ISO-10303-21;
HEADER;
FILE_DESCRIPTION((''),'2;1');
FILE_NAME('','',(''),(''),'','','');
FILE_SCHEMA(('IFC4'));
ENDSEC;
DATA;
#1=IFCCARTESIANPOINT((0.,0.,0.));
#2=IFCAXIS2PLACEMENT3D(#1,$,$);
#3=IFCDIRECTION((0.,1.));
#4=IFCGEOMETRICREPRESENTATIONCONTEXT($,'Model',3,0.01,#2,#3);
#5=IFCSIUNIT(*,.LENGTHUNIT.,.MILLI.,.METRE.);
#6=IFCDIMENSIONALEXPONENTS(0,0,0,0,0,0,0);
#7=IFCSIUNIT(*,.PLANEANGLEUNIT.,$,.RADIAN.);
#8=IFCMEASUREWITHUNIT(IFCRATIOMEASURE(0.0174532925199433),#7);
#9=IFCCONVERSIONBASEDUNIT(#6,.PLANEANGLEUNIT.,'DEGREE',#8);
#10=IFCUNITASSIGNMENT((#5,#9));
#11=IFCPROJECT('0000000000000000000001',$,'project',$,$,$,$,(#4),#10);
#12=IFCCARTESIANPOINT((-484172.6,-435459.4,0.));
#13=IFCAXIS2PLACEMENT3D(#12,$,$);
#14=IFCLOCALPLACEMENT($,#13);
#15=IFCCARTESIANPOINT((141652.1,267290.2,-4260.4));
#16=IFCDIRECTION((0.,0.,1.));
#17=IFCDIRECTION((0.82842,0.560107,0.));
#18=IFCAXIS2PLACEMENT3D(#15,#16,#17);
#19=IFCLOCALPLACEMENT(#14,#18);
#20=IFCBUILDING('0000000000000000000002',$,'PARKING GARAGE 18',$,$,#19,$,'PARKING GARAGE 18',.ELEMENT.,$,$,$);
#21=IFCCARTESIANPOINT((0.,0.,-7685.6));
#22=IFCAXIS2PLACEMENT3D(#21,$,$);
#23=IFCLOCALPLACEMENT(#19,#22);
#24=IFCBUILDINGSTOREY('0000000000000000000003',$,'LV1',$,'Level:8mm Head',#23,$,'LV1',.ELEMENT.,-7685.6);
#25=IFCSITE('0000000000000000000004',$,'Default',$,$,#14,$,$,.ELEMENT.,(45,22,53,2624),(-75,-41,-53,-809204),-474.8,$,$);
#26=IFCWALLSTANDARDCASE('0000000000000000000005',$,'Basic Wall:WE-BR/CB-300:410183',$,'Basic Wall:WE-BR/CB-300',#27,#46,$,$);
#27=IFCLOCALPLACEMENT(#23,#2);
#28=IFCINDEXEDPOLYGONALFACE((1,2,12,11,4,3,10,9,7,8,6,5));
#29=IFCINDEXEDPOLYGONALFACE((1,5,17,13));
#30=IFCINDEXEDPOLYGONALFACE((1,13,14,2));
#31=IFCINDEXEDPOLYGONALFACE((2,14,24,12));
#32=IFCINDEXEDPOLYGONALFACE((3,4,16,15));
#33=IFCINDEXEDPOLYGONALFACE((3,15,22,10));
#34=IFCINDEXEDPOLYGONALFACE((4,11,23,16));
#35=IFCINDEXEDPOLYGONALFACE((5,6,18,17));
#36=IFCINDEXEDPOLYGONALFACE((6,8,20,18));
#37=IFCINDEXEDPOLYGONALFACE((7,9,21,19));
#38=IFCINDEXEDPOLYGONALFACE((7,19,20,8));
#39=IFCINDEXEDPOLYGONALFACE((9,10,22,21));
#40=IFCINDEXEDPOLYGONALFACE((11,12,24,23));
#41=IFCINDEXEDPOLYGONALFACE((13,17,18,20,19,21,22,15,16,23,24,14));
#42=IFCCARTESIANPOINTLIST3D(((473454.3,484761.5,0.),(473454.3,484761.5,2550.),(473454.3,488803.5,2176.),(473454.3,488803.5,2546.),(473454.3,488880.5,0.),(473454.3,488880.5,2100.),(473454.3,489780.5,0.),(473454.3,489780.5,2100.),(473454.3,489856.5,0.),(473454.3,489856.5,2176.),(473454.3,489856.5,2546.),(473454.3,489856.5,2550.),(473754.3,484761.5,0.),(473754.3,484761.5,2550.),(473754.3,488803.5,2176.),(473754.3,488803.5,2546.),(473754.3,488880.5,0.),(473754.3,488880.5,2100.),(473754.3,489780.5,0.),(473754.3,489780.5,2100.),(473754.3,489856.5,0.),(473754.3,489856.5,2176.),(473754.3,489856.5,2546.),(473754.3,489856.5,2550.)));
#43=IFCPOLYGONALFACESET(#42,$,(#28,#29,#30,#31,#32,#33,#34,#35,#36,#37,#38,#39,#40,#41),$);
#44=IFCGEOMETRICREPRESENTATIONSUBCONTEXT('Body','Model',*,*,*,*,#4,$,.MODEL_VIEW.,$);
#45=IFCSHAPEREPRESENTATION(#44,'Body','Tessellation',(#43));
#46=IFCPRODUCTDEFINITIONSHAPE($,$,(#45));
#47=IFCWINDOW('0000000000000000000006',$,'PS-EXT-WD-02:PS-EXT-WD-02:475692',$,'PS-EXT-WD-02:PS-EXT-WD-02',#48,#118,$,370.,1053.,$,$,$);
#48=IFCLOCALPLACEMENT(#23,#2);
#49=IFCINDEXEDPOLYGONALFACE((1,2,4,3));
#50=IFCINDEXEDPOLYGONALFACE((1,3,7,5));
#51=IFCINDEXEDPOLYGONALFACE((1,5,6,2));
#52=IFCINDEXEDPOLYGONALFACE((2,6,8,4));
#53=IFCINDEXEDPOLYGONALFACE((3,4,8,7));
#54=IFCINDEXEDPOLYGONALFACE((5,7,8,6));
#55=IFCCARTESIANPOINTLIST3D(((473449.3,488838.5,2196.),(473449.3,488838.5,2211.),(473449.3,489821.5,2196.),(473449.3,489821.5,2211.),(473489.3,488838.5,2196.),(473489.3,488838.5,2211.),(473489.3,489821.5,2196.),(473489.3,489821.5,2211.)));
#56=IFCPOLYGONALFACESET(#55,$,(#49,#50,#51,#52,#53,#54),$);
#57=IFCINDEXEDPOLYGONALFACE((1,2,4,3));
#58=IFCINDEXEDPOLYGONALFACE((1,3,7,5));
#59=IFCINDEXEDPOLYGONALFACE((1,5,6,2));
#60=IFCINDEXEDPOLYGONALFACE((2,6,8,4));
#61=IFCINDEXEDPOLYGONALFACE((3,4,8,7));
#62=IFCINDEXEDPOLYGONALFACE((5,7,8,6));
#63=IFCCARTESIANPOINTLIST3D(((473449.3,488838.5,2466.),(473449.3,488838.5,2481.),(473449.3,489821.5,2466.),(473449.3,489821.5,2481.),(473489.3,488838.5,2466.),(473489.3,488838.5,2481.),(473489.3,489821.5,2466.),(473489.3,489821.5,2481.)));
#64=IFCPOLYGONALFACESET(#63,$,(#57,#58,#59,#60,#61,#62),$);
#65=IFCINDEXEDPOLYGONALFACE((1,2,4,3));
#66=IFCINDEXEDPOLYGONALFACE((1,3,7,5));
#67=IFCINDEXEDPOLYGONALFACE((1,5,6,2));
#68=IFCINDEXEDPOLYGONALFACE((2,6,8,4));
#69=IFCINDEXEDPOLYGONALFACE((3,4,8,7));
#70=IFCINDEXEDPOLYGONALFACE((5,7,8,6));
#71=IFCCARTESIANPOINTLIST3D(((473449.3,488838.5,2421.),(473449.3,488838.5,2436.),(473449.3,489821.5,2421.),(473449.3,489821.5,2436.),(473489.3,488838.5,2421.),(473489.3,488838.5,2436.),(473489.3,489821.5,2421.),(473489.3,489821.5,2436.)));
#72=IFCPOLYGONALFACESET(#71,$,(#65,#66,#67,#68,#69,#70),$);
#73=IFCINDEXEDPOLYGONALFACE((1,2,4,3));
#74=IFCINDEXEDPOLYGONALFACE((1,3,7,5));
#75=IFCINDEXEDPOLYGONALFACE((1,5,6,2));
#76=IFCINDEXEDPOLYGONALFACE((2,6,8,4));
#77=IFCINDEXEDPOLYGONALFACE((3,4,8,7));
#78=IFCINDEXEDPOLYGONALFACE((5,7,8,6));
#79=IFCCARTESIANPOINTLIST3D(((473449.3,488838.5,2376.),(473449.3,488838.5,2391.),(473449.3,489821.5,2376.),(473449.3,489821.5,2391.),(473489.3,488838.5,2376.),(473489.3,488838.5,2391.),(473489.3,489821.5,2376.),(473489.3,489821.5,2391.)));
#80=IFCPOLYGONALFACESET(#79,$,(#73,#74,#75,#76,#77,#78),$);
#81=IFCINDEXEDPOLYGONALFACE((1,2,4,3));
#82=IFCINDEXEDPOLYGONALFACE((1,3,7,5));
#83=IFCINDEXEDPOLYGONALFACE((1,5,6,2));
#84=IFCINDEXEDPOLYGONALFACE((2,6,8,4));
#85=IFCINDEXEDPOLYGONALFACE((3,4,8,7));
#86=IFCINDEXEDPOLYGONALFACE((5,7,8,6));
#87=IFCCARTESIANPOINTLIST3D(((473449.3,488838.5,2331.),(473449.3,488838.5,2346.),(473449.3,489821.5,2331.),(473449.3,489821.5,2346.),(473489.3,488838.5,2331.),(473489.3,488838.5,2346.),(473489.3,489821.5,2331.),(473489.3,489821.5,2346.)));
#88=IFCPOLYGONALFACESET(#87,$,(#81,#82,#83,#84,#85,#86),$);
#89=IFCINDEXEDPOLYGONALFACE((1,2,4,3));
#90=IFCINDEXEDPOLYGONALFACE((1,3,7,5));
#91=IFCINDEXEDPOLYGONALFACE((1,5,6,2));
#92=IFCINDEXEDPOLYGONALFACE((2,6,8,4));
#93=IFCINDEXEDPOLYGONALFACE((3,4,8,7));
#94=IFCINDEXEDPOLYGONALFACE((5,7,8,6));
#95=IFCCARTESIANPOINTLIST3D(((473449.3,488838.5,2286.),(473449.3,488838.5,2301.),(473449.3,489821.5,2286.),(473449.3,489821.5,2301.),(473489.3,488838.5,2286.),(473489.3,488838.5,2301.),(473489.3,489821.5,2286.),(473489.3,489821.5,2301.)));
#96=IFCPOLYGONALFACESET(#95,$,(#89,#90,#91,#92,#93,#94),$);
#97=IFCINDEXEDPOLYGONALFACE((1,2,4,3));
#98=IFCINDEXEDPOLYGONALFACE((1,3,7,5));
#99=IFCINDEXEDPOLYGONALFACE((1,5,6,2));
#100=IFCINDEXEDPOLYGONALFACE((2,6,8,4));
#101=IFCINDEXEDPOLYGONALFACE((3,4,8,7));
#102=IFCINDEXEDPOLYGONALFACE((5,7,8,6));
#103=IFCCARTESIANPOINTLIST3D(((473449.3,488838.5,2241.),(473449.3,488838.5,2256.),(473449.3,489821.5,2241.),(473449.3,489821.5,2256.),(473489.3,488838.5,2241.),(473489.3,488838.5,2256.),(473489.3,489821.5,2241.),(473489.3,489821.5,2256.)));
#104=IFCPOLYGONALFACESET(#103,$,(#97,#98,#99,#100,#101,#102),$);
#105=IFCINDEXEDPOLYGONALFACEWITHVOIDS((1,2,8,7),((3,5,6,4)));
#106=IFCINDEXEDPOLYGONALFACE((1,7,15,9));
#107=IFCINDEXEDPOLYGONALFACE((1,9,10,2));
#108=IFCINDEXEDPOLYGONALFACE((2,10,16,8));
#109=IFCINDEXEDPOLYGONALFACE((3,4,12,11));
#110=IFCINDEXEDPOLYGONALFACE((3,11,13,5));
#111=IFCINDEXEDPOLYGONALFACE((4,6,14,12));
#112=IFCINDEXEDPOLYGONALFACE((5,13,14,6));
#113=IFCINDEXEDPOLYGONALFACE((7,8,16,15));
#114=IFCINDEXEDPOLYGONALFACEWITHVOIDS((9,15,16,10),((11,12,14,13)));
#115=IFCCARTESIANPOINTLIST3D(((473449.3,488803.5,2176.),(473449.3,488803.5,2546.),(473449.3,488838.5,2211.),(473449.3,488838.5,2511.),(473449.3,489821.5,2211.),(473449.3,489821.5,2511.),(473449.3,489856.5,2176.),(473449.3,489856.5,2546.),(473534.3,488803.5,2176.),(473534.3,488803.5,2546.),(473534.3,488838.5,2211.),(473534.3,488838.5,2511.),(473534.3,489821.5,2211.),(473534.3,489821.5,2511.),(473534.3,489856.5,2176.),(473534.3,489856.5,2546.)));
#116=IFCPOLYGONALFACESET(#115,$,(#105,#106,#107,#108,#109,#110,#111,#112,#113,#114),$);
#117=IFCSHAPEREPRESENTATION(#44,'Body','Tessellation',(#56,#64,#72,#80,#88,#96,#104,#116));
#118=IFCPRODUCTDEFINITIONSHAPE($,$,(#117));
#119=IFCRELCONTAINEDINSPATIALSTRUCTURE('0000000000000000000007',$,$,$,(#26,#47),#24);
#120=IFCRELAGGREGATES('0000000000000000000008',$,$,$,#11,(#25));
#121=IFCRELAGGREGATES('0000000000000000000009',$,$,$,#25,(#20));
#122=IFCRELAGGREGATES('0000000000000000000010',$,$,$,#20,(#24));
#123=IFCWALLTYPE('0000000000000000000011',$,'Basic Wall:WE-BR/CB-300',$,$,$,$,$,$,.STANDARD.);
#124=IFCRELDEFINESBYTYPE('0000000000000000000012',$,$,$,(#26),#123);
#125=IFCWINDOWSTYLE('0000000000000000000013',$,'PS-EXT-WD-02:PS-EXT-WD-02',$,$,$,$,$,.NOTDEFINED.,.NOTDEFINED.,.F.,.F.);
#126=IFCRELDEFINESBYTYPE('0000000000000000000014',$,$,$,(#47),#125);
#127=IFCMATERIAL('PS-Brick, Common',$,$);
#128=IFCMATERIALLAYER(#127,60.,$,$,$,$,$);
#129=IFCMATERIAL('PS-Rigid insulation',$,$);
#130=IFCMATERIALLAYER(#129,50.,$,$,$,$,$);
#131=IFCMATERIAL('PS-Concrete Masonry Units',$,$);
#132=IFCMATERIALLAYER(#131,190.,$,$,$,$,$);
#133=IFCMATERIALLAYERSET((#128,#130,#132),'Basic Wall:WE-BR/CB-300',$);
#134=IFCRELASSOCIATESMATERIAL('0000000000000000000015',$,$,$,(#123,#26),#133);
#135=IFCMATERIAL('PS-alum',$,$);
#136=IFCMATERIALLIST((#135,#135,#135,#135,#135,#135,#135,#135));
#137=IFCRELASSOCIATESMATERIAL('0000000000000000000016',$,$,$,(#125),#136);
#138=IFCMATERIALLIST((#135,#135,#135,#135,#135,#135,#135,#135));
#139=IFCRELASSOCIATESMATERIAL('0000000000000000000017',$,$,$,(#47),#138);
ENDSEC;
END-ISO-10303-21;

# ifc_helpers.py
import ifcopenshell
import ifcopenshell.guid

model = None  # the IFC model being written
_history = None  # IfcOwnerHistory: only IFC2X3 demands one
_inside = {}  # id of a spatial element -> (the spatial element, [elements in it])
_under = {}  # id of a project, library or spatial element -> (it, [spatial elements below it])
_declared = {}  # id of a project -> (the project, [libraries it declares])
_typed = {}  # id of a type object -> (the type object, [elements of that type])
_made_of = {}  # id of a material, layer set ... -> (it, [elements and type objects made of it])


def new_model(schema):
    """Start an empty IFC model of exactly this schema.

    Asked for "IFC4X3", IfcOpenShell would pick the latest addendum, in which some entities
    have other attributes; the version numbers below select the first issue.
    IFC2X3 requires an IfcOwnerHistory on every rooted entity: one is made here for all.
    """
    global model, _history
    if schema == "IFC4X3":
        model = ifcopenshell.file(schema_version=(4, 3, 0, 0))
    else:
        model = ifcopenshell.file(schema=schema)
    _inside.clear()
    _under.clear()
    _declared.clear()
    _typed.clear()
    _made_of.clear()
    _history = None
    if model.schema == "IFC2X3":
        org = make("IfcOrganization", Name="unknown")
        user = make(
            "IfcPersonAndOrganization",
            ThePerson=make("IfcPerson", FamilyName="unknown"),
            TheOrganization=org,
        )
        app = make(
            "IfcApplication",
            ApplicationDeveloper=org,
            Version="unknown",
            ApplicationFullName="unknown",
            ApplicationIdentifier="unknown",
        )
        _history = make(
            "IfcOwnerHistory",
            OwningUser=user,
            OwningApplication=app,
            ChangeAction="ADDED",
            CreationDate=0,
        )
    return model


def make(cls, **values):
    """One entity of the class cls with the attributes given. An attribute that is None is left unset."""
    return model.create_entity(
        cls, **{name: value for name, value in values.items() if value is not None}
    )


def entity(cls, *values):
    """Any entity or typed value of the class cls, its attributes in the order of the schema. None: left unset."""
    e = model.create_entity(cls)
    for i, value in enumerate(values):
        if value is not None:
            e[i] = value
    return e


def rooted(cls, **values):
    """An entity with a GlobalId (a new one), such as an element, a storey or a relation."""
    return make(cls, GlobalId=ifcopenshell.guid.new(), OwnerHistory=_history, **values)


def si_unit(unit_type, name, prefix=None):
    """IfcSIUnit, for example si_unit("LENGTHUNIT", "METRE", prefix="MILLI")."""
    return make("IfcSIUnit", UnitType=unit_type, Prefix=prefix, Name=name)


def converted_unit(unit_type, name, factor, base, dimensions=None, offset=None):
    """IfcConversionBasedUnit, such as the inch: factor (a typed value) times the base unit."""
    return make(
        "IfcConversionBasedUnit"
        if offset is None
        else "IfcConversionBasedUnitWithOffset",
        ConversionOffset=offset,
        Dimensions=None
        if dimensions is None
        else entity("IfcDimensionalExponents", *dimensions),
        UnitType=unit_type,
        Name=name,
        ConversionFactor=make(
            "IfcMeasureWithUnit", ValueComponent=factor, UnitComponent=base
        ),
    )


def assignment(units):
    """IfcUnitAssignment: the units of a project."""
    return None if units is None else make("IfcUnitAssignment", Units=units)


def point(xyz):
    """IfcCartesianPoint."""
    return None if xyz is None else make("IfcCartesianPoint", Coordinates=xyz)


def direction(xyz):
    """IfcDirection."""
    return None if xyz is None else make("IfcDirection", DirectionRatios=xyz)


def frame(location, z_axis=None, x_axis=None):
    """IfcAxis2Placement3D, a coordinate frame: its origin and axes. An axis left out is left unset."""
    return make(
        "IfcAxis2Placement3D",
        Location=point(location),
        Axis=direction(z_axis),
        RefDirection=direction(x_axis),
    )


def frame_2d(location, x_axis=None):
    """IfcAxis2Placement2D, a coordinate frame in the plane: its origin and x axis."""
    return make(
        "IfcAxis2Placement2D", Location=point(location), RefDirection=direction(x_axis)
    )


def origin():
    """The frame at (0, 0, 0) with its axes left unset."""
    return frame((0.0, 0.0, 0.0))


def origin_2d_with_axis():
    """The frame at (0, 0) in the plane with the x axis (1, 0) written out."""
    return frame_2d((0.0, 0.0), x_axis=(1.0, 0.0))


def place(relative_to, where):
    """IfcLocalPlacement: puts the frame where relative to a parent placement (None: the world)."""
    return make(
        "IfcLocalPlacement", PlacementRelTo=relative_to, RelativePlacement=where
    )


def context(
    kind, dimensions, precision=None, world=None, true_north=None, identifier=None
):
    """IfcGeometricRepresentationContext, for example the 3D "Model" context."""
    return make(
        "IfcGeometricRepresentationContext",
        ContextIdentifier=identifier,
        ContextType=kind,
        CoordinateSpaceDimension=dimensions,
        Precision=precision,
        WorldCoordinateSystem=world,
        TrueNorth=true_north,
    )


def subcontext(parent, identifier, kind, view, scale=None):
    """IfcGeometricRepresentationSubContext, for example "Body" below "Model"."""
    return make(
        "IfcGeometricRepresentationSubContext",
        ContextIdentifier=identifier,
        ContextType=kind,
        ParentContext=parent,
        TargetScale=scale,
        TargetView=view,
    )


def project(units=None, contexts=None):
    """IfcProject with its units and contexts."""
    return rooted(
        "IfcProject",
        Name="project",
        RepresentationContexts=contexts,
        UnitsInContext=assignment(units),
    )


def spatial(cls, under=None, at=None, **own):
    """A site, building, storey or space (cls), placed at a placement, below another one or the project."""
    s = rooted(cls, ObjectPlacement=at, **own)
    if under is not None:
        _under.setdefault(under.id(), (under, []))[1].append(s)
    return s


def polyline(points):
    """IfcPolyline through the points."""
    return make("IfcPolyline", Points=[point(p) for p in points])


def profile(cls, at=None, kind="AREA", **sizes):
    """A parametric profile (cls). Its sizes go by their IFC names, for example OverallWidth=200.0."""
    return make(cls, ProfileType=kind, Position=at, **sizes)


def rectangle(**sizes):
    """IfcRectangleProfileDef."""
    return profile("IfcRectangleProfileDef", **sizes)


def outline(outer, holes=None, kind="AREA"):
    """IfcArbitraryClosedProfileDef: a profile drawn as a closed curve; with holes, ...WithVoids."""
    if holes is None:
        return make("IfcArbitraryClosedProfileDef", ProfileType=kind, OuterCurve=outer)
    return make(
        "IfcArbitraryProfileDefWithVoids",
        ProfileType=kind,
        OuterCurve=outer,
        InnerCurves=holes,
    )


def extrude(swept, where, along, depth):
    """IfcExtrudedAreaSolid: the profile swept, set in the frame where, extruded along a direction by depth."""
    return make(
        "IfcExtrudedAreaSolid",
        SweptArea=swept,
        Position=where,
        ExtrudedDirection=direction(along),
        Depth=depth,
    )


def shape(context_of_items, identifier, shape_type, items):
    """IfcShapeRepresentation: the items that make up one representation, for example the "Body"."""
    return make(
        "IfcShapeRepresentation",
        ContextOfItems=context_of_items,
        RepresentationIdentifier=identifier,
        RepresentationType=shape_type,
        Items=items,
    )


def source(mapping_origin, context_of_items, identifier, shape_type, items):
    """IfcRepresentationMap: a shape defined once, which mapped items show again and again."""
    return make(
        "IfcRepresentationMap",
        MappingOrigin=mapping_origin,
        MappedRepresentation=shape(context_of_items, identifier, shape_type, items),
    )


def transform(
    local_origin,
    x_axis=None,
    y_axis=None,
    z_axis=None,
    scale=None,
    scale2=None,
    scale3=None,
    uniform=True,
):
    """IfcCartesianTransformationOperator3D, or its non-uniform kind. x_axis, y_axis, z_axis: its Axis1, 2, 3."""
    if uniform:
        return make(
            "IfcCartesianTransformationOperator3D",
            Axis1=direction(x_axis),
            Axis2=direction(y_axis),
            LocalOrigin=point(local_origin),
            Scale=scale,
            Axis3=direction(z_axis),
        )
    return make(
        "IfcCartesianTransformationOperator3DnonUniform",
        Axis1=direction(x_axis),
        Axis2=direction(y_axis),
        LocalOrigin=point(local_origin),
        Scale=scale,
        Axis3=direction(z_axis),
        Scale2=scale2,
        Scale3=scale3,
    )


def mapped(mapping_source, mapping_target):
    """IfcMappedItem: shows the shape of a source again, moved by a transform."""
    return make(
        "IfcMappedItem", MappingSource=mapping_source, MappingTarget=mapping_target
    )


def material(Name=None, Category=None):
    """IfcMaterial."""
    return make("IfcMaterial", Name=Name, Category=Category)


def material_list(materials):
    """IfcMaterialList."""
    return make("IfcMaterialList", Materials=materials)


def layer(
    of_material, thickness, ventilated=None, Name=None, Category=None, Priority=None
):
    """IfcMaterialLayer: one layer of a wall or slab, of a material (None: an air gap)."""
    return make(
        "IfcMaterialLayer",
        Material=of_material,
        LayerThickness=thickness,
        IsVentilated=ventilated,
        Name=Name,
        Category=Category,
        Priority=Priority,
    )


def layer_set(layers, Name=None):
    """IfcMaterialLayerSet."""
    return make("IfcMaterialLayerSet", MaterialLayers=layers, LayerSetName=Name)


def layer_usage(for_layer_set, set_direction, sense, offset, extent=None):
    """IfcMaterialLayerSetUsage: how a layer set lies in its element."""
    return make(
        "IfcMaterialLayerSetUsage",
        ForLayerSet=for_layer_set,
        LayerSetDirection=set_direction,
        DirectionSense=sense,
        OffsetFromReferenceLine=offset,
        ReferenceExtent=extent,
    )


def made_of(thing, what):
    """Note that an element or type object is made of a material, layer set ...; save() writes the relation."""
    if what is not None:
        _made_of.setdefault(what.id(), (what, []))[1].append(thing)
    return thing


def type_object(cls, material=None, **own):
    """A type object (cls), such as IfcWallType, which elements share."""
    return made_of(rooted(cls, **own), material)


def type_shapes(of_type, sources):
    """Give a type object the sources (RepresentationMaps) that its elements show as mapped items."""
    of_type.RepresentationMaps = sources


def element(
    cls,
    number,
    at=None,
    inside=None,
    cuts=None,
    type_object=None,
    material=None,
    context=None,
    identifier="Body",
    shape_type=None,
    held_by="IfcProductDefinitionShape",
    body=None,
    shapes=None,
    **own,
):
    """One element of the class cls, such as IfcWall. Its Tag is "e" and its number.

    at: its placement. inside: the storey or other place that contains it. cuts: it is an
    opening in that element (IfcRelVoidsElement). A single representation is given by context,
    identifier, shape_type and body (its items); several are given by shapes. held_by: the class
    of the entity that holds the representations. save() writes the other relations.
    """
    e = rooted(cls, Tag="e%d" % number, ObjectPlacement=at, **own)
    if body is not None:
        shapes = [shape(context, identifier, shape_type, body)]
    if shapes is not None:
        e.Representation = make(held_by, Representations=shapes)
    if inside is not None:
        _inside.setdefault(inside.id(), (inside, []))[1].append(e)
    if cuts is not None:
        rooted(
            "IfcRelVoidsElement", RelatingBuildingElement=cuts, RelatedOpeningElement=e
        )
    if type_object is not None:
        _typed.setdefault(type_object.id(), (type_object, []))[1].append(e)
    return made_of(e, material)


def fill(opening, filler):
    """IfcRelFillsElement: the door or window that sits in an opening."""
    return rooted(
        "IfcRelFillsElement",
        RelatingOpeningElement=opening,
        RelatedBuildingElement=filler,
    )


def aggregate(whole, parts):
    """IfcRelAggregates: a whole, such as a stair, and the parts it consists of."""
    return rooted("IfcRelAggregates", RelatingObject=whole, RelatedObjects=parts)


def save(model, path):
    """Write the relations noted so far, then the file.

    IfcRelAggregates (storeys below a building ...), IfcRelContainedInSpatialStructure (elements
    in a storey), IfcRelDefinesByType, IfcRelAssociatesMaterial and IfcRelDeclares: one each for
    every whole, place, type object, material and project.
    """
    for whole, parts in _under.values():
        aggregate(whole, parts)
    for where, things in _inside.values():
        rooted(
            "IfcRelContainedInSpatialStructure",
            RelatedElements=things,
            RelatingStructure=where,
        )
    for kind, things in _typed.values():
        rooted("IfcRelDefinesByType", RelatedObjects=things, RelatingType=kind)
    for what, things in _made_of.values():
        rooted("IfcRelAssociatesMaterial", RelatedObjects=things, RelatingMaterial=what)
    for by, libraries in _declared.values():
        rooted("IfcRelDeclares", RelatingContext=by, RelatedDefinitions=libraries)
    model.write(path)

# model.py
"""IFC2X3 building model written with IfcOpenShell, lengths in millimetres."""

from ifc_helpers import new_model, entity, si_unit, converted_unit, direction, frame, frame_2d, origin, origin_2d_with_axis, place, context, subcontext, project, spatial, polyline, rectangle, outline, extrude, source, transform, mapped, material, material_list, layer, layer_set, layer_usage, type_object, type_shapes, element, fill, save


model = new_model("IFC2X3")

# Units and contexts
model_context = context("Model", 3, precision=0.01, world=origin(), true_north=direction((0.0, 1.0)))
body_context = subcontext(model_context, "Body", "Model", "MODEL_VIEW")
ifc_project = project(units=[si_unit("LENGTHUNIT", "METRE", prefix="MILLI"), converted_unit("PLANEANGLEUNIT", "DEGREE", entity("IfcRatioMeasure", 0.0174532925199433), si_unit("PLANEANGLEUNIT", "RADIAN"), dimensions=[0, 0, 0, 0, 0, 0, 0])], contexts=[model_context])

# Site, building, storey
site_placement = place(None, frame((-484172.6, -435459.4, 0.0)))
site = spatial("IfcSite", under=ifc_project, at=site_placement, Name="Default", CompositionType="ELEMENT", RefLatitude=(45, 22, 53, 2624), RefLongitude=(-75, -41, -53, -809204), RefElevation=-474.8)
building_placement = place(site_placement, frame((141652.1, 267290.2, -4260.4), z_axis=(0.0, 0.0, 1.0), x_axis=(0.82842, 0.560107, 0.0)))
building = spatial("IfcBuilding", under=site, at=building_placement, Name="PARKING GARAGE 18", LongName="PARKING GARAGE 18", CompositionType="ELEMENT")
storey_placement = place(building_placement, frame((0.0, 0.0, -7685.6)))
storey = spatial("IfcBuildingStorey", under=building, at=storey_placement, Name="LV1", ObjectType="Level:8mm Head", LongName="LV1", CompositionType="ELEMENT", Elevation=-7685.6)

# Shared definitions
ifc_material_1 = material(Name="PS-Concrete Masonry Units")
ifc_material_2 = material(Name="PS-Rigid insulation")

# Wall, openings, window
ifc_material_3 = material(Name="PS-Brick, Common")
ifc_layer_1 = layer(ifc_material_3, 60.0)
ifc_layer_2 = layer(ifc_material_2, 50.0)
ifc_layer_3 = layer(ifc_material_1, 190.0)
ifc_layer_set_1 = layer_set([ifc_layer_1, ifc_layer_2, ifc_layer_3], Name="Basic Wall:WE-BR/CB-300")
ifc_layer_usage_1 = layer_usage(ifc_layer_set_1, "AXIS2", "NEGATIVE", 150.0)
wall_type_1 = type_object("IfcWallType", Name="Basic Wall:WE-BR/CB-300", PredefinedType="STANDARD", material=ifc_layer_set_1)
wall_1_placement = place(storey_placement, frame((473604.3, 484761.5, 0.0), z_axis=(0.0, 0.0, 1.0), x_axis=(0.0, 1.0, 0.0)))
wall_1 = element("IfcWallStandardCase", 1, at=wall_1_placement, inside=storey, type_object=wall_type_1, material=ifc_layer_usage_1, Name="Basic Wall:WE-BR/CB-300:410183", ObjectType="Basic Wall:WE-BR/CB-300", context=body_context, shape_type="SweptSolid", body=[
    extrude(rectangle(XDim=5095.0, YDim=300.0, at=frame_2d((2547.5, 0.0), x_axis=(-1.0, 0.0))), origin(), (0.0, 0.0, 1.0), 2550.0),
])
opening_1_placement = place(wall_1_placement, origin())
element("IfcOpeningElement", 2, at=opening_1_placement, cuts=wall_1, ObjectType="Opening", context=body_context, shape_type="SweptSolid", body=[
    extrude(rectangle(XDim=2100.0, YDim=900.0, at=frame_2d((0.0, 0.0), x_axis=(1.0, 0.0))), frame((4569.0, -1674.0, 1050.0), z_axis=(0.0, 1.0, 0.0), x_axis=(0.0, 0.0, 1.0)), (0.0, 0.0, 1.0), 3048.0),
])
opening_2_placement = place(wall_1_placement, frame((4042.0, -150.0, 2176.0)))
opening_2 = element("IfcOpeningElement", 3, at=opening_2_placement, cuts=wall_1, ObjectType="Opening", context=body_context, shape_type="SweptSolid", body=[
    extrude(rectangle(XDim=370.0, YDim=1053.0, at=frame_2d((185.0, 526.5), x_axis=(1.0, 0.0))), frame((0.0, 0.0, 0.0), z_axis=(0.0, 1.0, 0.0), x_axis=(0.0, 0.0, 1.0)), (0.0, 0.0, 1.0), 300.0),
])
ifc_material_4 = material(Name="PS-alum")
ifc_material_list_1 = material_list([ifc_material_4, ifc_material_4, ifc_material_4, ifc_material_4, ifc_material_4, ifc_material_4, ifc_material_4, ifc_material_4])
ifc_material_list_2 = material_list([ifc_material_4, ifc_material_4, ifc_material_4, ifc_material_4, ifc_material_4, ifc_material_4, ifc_material_4, ifc_material_4])
window_style = type_object("IfcWindowStyle", Name="PS-EXT-WD-02:PS-EXT-WD-02", ConstructionType="NOTDEFINED", OperationType="NOTDEFINED", ParameterTakesPrecedence=False, Sizeable=False, material=ifc_material_list_2)
shared_shape_1 = source(origin(), body_context, "Body", "SweptSolid", [
    extrude(rectangle(XDim=983.0, YDim=40.0, at=frame_2d((0.0, 0.0), x_axis=(1.0, 0.0))), frame((526.5, 285.0, 20.0)), (0.0, 0.0, 1.0), 15.0),
    extrude(rectangle(XDim=983.0, YDim=40.0, at=frame_2d((0.0, 0.0), x_axis=(1.0, 0.0))), frame((526.5, 285.0, 290.0)), (0.0, 0.0, 1.0), 15.0),
    extrude(rectangle(XDim=983.0, YDim=40.0, at=origin_2d_with_axis()), frame((526.5, 285.0, 245.0)), (0.0, 0.0, 1.0), 15.0),
    extrude(rectangle(XDim=983.0, YDim=40.0, at=frame_2d((0.0, 0.0), x_axis=(1.0, 0.0))), frame((526.5, 285.0, 200.0)), (0.0, 0.0, 1.0), 15.0),
    extrude(rectangle(XDim=983.0, YDim=40.0, at=origin_2d_with_axis()), frame((526.5, 285.0, 155.0)), (0.0, 0.0, 1.0), 15.0),
    extrude(rectangle(XDim=983.0, YDim=40.0, at=frame_2d((0.0, 0.0), x_axis=(1.0, 0.0))), frame((526.5, 285.0, 110.0)), (0.0, 0.0, 1.0), 15.0),
    extrude(rectangle(XDim=983.0, YDim=40.0, at=origin_2d_with_axis()), frame((526.5, 285.0, 65.0)), (0.0, 0.0, 1.0), 15.0),
    extrude(outline(polyline([(-185.0, -526.5), (185.0, -526.5), (185.0, 526.5), (-185.0, 526.5), (-185.0, -526.5)]), holes=[polyline([(150.0, -491.5), (-150.0, -491.5), (-150.0, 491.5), (150.0, 491.5), (150.0, -491.5)])]), frame((526.5, 220.0, 185.0), z_axis=(0.0, 1.0, 0.0), x_axis=(0.0, 0.0, 1.0)), (0.0, 0.0, 1.0), 85.0),
])
type_shapes(window_style, [shared_shape_1])
window_placement = place(opening_2_placement, origin())
window = element("IfcWindow", 4, at=window_placement, inside=storey, type_object=window_style, material=ifc_material_list_1, Name="PS-EXT-WD-02:PS-EXT-WD-02:475692", ObjectType="PS-EXT-WD-02:PS-EXT-WD-02", OverallHeight=370.0, OverallWidth=1053.0, context=body_context, shape_type="MappedRepresentation", body=[
    mapped(shared_shape_1, transform((0.0, 0.0, 0.0), scale=1.0)),
])
fill(opening_2, window)

save(model, "model.ifc")
